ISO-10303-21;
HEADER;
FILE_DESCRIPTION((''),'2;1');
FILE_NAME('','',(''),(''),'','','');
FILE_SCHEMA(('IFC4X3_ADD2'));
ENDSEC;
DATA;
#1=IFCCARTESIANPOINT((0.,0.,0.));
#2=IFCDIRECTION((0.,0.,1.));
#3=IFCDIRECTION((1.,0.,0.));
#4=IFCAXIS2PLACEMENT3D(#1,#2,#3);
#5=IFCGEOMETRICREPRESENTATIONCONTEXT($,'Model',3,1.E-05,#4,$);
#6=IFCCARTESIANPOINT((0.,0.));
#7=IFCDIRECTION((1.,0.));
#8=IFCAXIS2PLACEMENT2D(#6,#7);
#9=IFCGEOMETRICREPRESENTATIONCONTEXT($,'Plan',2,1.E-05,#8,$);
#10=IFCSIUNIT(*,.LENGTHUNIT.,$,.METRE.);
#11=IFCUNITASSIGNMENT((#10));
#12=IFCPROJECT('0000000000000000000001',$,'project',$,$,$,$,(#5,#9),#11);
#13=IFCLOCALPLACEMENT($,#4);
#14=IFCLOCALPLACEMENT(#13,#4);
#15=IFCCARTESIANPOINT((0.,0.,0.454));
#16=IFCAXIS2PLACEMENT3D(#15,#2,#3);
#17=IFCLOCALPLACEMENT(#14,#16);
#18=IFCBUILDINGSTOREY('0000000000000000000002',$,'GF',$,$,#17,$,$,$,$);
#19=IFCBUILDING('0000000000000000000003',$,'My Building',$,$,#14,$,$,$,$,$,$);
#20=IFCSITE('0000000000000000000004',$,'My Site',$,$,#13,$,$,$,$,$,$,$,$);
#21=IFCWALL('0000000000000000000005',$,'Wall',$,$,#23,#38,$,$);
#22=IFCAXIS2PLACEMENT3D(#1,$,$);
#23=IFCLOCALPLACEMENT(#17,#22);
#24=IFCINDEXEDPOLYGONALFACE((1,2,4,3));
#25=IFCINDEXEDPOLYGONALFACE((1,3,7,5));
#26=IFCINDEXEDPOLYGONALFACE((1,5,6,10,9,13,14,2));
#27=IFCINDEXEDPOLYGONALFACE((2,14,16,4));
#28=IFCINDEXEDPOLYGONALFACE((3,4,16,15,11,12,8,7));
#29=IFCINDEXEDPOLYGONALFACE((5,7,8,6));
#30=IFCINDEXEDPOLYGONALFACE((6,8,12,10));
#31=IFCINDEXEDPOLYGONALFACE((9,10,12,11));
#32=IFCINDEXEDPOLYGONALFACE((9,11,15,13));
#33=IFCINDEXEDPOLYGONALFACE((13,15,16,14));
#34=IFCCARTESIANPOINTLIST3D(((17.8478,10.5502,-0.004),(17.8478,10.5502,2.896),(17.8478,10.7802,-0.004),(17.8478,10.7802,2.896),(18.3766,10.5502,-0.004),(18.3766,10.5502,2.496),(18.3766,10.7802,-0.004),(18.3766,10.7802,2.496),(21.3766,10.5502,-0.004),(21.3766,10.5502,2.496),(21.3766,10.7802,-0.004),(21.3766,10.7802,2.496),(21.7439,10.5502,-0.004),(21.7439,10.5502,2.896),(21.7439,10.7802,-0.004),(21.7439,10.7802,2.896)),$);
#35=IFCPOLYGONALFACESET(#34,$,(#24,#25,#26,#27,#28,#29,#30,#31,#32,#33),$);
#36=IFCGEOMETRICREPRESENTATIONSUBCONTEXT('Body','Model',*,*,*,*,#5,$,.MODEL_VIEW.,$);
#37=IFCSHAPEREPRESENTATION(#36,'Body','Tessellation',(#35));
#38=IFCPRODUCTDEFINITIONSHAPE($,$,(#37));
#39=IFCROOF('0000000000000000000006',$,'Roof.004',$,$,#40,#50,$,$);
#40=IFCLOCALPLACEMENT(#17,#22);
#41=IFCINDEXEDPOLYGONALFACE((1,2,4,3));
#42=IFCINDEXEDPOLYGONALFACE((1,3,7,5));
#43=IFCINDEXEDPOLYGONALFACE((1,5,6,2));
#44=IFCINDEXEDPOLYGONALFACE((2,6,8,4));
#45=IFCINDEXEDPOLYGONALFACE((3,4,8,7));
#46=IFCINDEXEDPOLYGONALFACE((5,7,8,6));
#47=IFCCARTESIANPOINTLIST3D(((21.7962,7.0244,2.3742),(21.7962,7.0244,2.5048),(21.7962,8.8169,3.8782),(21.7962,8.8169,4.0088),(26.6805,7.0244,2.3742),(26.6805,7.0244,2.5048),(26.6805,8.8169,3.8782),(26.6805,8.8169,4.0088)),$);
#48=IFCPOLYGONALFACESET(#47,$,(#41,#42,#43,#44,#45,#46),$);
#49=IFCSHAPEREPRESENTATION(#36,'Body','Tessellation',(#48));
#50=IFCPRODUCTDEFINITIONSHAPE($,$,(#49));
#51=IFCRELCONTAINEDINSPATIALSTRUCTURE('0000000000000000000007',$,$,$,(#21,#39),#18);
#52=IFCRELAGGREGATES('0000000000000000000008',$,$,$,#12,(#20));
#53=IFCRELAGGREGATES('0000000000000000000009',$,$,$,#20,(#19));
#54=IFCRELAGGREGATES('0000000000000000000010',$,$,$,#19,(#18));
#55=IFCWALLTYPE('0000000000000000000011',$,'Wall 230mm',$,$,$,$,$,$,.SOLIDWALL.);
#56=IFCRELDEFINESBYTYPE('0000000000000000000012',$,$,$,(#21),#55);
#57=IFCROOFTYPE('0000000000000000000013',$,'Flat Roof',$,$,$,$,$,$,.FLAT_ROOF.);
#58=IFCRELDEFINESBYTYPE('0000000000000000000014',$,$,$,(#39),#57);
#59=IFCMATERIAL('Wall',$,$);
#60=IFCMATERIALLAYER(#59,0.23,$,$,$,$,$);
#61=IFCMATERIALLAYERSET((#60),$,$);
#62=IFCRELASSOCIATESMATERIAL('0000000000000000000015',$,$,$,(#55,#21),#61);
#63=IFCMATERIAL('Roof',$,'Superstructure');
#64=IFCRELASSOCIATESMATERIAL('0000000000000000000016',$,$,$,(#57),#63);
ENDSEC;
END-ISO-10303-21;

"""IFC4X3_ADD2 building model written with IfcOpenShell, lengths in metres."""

from ifc_helpers import new_model, si_unit, frame, origin_with_axes, origin_2d_with_axis, place, context, subcontext, project, spatial, polyline, line, indexed_curve, outline, extrude, source, transform, mapped, material, layer, layer_set, layer_usage, type_object, element, save


model = new_model("IFC4X3_ADD2")

# Units and contexts
model_context = context("Model", 3, precision=1e-05, world=origin_with_axes())
plan_context = context("Plan", 2, precision=1e-05, world=origin_2d_with_axis())
body_context = subcontext(model_context, "Body", "Model", "MODEL_VIEW")
ifc_project = project(units=[si_unit("LENGTHUNIT", "METRE")], contexts=[model_context, plan_context])

# Site, building, storey
site_placement = place(None, origin_with_axes())
site = spatial("IfcSite", under=ifc_project, at=site_placement, Name="My Site")
building_placement = place(site_placement, origin_with_axes())
building = spatial("IfcBuilding", under=site, at=building_placement, Name="My Building")
storey_placement = place(building_placement, frame((0.0, 0.0, 0.454), z_axis=(0.0, 0.0, 1.0), x_axis=(1.0, 0.0, 0.0)))
storey = spatial("IfcBuildingStorey", under=building, at=storey_placement, Name="GF")

# Wall, opening
ifc_material_1 = material(Name="Wall")
ifc_layer = layer(ifc_material_1, 0.23)
ifc_layer_set = layer_set([ifc_layer])
ifc_layer_usage = layer_usage(ifc_layer_set, "AXIS2", "POSITIVE", 0.0)
wall_type = type_object("IfcWallType", Name="Wall 230mm", PredefinedType="SOLIDWALL", material=ifc_layer_set)
wall_placement = place(storey_placement, frame((21.7439, 10.7802, -0.004), z_axis=(0.0, 0.0, 1.0), x_axis=(-1.0, 0.0, 0.0)))
wall = element("IfcWall", 1, at=wall_placement, inside=storey, type_object=wall_type, material=ifc_layer_usage, Name="Wall", context=body_context, shape_type="SweptSolid", body=[
    extrude(outline(indexed_curve([(0.0, 0.0), (0.0, 0.23), (3.8962, 0.23), (3.8962, 0.0), (0.0, 0.0)], self_intersect=False)), origin_with_axes(), (0.0, 0.0, 1.0), 2.9),
])
shared_shape = source(origin_with_axes(), body_context, "Body", "SweptSolid", [
    extrude(outline(indexed_curve([(0.0, 0.0), (3.0, 0.0), (3.0, 2.5), (0.0, 2.5)], segments=[line(1, 2, 3, 4, 1)])), frame((0.0, -0.6, 0.0), z_axis=(0.0, -1.0, 0.0), x_axis=(1.0, 0.0, 0.0)), (0.0, 0.0, -1.0), 1.2),
])
opening_placement = place(wall_placement, frame((0.3674, 0.0, 0.0), z_axis=(0.0, 0.0, 1.0), x_axis=(1.0, 0.0, 0.0)))
element("IfcOpeningElement", 2, at=opening_placement, cuts=wall, PredefinedType="OPENING", context=body_context, shape_type="MappedRepresentation", body=[
    mapped(shared_shape, transform((0.0, 0.0, 0.0), x_axis=(1.0, 0.0, 0.0), y_axis=(0.0, 1.0, 0.0), z_axis=(0.0, 0.0, 1.0), scale=1.0)),
])

# Roof
ifc_material_2 = material(Name="Roof", Category="Superstructure")
roof_type = type_object("IfcRoofType", Name="Flat Roof", PredefinedType="FLAT_ROOF", material=ifc_material_2)
roof_placement = place(storey_placement, frame((21.7962, 8.0241, 3.2131), z_axis=(0.0, -0.642788, 0.766044), x_axis=(1.0, 0.0, 0.0)))
element("IfcRoof", 3, at=roof_placement, inside=storey, type_object=roof_type, Name="Roof.004", context=body_context, shape_type="SweptSolid", body=[
    extrude(outline(polyline([(-2.4421, -0.0653), (2.4421, -0.0653), (2.4421, 0.0653), (-2.4421, 0.0653), (-2.4421, -0.0653)])), frame((2.4421, 1.0768, 0.05), z_axis=(0.0, 0.766044, -0.642788), x_axis=(1.0, 0.0, 0.0)), (0.0, 0.642788, -0.766044), 2.3398),
])

save(model, "model.ifc")
